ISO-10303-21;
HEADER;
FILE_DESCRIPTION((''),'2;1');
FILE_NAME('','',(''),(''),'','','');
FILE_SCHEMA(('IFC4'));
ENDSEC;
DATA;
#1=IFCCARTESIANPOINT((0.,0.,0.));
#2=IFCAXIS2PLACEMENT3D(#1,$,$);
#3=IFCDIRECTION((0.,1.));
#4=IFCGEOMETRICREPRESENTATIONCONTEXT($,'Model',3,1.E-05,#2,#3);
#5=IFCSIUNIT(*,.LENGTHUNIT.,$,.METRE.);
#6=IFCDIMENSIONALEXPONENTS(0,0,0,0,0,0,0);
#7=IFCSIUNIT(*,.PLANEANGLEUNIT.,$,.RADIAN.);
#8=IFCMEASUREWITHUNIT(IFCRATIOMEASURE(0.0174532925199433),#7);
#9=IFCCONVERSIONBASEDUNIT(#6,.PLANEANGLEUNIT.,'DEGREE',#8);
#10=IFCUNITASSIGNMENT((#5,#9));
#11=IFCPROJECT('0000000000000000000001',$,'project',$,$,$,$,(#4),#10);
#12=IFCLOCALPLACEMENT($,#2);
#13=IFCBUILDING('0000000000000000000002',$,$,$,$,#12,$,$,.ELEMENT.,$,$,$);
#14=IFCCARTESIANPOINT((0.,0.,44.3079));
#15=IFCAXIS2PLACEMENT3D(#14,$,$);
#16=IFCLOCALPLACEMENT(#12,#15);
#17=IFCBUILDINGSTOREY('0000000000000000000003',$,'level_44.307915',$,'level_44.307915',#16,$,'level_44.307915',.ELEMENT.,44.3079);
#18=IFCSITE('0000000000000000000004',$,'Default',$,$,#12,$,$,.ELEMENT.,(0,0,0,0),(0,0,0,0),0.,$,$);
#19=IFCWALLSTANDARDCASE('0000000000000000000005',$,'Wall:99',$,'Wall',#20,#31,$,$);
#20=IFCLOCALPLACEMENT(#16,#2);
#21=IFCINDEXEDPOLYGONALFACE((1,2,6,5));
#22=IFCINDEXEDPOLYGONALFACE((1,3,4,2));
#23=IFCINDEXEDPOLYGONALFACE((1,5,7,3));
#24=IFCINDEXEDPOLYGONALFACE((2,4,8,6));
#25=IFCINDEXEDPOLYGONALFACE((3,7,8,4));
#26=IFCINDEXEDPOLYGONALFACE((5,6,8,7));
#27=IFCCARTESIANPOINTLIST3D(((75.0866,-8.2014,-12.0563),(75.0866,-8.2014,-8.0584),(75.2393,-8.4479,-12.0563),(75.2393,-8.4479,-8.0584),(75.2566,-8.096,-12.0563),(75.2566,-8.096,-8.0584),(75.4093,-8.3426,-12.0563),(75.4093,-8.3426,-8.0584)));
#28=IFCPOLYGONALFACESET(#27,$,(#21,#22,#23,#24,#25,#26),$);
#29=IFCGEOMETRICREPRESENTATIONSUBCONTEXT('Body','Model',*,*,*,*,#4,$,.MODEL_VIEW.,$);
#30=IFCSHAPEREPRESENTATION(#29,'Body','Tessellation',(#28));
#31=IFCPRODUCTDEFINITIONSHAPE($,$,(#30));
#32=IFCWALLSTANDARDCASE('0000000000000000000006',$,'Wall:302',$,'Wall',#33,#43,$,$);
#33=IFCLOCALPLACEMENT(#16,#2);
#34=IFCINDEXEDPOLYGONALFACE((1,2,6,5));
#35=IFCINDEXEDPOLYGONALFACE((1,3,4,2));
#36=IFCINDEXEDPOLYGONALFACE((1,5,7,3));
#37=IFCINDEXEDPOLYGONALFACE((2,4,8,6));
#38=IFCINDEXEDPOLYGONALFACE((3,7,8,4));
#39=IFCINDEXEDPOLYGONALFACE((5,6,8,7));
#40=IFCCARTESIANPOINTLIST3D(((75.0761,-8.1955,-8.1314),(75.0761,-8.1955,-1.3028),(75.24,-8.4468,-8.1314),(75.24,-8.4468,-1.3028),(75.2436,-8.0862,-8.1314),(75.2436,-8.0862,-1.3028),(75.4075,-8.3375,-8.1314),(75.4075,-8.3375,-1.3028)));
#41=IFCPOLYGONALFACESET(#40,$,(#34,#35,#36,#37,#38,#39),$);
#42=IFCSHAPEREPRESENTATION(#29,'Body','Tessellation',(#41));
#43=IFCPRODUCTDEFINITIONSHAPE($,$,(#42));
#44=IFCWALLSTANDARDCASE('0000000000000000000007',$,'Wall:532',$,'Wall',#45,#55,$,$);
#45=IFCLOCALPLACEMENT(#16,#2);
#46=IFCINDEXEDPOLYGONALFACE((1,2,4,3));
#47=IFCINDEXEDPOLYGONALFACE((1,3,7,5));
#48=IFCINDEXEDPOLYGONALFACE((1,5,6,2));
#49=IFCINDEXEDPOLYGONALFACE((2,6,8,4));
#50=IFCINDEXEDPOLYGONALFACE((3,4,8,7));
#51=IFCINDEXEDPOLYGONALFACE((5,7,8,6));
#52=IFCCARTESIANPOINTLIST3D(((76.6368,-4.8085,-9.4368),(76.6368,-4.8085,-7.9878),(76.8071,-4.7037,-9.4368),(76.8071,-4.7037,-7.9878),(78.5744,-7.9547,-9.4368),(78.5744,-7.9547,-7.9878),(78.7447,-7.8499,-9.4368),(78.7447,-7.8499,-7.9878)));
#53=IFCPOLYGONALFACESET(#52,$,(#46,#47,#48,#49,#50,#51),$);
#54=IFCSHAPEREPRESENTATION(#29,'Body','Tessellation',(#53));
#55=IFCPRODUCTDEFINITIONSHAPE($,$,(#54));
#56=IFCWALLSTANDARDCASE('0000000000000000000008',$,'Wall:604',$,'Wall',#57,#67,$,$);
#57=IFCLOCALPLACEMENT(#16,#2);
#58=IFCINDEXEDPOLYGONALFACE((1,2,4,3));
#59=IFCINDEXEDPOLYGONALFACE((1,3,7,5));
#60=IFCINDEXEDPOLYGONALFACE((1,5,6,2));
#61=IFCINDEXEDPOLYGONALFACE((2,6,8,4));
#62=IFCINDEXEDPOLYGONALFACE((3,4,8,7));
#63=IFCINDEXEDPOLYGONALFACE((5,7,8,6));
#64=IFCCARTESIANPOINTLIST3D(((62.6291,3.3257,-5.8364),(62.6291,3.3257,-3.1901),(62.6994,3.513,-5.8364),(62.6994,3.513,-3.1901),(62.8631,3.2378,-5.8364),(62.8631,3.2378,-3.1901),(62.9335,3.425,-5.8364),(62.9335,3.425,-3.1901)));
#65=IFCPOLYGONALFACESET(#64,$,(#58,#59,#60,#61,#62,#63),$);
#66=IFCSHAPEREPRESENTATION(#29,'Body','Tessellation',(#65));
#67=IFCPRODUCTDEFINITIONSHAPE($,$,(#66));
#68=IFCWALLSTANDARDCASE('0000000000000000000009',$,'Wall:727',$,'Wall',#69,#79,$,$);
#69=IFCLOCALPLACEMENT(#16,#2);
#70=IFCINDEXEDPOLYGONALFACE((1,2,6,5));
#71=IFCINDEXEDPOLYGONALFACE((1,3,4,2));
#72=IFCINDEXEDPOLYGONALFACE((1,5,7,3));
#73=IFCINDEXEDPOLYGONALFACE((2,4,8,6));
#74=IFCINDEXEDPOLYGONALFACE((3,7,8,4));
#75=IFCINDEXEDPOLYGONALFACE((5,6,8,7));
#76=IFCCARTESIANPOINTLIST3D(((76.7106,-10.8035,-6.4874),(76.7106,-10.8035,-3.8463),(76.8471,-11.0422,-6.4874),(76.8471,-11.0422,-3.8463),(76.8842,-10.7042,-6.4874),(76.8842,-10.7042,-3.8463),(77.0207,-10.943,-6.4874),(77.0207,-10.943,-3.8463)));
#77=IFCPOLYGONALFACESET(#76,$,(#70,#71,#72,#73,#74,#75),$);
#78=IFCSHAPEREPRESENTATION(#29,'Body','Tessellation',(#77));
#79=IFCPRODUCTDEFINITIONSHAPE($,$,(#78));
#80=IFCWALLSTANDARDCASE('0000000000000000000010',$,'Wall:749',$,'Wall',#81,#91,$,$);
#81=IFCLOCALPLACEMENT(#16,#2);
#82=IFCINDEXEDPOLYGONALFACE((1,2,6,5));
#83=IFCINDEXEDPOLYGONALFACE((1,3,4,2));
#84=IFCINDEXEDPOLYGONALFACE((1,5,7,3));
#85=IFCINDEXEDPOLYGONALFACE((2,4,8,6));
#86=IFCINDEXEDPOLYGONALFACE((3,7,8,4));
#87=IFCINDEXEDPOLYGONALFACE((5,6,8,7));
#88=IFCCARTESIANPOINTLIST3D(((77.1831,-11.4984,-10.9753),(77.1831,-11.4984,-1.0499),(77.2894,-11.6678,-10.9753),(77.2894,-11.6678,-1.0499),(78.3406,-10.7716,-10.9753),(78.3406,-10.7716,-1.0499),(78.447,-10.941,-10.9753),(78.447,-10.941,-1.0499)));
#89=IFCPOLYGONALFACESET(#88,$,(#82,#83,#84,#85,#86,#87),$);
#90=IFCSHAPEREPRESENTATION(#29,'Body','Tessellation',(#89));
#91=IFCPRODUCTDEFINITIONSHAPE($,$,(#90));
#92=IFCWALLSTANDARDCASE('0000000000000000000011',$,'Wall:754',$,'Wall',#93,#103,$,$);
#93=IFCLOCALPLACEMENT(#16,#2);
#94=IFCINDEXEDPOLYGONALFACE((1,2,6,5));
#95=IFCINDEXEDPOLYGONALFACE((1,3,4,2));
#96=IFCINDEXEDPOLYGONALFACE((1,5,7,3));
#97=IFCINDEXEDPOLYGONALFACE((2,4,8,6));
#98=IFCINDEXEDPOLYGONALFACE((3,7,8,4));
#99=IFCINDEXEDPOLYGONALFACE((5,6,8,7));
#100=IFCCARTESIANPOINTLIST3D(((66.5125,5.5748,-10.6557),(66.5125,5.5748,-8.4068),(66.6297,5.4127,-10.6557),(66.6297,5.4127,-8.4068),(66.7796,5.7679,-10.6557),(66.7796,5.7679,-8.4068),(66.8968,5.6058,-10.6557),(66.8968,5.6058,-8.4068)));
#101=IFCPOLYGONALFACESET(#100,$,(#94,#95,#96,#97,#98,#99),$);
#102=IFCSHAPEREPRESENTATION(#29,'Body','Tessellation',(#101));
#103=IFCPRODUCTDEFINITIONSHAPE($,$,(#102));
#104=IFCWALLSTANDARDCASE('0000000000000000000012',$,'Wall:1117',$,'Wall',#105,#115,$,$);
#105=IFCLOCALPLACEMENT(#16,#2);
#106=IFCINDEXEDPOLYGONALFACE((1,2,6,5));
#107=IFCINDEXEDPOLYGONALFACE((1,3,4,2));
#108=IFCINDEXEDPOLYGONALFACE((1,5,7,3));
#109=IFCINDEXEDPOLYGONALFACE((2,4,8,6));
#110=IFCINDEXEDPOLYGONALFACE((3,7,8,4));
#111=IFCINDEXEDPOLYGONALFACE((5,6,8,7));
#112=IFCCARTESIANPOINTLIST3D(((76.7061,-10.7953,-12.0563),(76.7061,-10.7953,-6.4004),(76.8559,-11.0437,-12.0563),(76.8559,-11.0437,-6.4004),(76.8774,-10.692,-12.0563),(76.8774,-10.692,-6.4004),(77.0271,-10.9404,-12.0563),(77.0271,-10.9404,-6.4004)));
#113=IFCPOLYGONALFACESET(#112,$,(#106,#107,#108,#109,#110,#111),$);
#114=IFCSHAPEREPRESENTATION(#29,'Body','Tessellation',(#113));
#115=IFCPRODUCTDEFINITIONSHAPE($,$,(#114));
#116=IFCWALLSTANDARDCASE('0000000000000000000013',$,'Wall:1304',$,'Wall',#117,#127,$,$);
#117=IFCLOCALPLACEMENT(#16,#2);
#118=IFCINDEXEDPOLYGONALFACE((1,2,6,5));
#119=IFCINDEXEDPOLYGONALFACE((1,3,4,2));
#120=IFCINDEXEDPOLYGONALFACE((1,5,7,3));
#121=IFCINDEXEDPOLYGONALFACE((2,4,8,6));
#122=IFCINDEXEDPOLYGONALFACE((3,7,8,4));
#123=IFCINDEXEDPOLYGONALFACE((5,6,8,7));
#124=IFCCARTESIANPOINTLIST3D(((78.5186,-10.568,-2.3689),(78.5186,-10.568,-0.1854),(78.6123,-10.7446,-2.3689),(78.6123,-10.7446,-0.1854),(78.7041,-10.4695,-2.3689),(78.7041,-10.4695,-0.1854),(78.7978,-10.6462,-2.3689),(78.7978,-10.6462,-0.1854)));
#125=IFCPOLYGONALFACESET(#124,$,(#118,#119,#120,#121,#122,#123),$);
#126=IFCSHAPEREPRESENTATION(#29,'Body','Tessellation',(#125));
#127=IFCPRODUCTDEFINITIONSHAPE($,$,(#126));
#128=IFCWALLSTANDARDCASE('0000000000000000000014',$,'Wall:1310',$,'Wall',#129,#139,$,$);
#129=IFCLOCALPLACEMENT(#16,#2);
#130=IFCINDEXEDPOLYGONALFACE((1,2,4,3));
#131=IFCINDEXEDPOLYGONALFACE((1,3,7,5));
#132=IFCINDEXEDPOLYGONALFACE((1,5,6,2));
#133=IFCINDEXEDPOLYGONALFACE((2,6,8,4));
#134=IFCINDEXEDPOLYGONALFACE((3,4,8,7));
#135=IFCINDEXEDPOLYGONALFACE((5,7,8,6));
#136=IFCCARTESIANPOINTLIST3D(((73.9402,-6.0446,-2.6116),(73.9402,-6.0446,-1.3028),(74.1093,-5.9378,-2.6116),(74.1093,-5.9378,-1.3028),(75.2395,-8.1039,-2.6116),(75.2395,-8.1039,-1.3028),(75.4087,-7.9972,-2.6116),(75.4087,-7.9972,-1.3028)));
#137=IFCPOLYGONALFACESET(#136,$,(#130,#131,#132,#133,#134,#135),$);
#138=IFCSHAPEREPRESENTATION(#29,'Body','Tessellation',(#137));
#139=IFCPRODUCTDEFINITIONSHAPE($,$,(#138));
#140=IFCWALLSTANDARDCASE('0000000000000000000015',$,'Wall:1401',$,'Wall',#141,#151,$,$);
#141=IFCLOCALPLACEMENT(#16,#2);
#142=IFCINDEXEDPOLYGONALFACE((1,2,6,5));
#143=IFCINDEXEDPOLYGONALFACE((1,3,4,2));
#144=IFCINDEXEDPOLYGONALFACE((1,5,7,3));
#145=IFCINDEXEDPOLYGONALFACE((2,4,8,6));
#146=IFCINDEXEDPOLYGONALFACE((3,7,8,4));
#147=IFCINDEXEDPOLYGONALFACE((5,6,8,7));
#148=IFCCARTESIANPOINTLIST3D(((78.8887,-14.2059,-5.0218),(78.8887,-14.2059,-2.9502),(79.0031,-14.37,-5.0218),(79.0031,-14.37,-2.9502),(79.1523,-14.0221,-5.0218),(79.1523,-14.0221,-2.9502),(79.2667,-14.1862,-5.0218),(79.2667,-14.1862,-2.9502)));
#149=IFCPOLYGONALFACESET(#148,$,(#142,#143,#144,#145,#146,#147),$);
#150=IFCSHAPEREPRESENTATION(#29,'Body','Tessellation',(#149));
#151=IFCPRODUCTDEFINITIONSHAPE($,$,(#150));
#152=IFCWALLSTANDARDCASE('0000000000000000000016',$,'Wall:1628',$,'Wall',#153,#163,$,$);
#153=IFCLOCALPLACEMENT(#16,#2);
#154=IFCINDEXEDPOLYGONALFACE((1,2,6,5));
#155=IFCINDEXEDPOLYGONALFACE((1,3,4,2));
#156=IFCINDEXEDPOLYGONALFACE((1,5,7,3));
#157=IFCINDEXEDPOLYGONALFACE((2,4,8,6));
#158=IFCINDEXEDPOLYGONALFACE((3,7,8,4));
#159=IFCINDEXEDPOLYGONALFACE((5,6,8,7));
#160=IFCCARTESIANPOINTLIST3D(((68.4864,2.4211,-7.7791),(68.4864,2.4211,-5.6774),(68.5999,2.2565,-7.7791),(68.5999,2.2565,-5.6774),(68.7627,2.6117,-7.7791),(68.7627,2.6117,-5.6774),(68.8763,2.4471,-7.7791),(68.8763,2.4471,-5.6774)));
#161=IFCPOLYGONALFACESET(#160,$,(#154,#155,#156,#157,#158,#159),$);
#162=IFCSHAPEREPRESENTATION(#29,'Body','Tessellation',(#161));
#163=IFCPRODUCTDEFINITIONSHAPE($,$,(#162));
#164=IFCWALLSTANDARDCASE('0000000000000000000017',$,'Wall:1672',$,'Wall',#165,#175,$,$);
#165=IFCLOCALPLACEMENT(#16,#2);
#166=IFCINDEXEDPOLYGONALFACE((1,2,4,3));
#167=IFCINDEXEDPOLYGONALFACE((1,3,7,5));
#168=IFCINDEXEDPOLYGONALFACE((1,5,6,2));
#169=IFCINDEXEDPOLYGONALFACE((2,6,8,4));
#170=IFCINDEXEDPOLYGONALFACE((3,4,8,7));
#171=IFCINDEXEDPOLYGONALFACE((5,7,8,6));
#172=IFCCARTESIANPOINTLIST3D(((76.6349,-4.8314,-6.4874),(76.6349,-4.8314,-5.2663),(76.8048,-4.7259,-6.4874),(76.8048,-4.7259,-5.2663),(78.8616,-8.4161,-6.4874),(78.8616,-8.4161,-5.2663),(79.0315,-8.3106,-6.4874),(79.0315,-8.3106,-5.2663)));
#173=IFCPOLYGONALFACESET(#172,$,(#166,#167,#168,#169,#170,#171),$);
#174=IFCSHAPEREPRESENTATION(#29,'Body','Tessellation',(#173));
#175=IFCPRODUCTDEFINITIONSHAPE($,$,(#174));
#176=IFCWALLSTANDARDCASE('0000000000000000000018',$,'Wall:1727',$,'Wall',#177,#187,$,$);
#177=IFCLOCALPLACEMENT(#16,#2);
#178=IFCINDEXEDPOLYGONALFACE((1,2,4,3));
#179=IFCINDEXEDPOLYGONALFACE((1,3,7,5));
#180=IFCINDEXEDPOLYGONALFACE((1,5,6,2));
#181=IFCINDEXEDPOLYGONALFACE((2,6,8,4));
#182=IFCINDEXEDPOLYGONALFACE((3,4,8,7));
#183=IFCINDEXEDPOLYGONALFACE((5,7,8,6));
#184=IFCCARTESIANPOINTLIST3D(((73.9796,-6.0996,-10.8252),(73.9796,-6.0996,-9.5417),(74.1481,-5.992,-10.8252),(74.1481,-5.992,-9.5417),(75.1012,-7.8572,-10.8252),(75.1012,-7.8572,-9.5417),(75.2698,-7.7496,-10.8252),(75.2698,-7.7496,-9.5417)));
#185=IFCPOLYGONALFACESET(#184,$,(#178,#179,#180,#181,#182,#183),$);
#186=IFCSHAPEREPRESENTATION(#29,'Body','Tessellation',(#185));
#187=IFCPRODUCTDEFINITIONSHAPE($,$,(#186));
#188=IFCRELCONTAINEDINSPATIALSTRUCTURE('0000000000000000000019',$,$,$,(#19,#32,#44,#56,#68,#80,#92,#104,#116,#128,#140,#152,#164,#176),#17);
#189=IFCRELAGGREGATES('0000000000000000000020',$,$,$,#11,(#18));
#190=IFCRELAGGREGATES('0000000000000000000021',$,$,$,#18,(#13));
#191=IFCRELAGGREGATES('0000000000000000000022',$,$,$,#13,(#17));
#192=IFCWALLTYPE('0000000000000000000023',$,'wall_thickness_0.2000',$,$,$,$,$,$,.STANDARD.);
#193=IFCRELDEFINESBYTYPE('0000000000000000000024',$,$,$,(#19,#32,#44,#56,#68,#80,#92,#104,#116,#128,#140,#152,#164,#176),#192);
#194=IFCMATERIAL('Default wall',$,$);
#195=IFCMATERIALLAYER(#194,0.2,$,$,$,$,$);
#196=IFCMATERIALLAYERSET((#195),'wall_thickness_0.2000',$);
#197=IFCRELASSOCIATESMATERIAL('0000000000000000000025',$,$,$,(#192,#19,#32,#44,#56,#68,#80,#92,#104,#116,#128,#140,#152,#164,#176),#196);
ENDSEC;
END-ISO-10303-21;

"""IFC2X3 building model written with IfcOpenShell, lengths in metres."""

from ifc_helpers import new_model, entity, si_unit, converted_unit, direction, frame, origin, place, context, subcontext, project, spatial, polyline, outline, extrude, material, layer, layer_set, layer_usage, type_object, element, save


model = new_model("IFC2X3")

# Units and contexts
model_context = context("Model", 3, precision=1e-05, world=origin(), true_north=direction((0.0, 1.0)))
body_context = subcontext(model_context, "Body", "Model", "MODEL_VIEW")
ifc_project = project(units=[si_unit("LENGTHUNIT", "METRE"), converted_unit("PLANEANGLEUNIT", "DEGREE", entity("IfcRatioMeasure", 0.0174532925199433), si_unit("PLANEANGLEUNIT", "RADIAN"), dimensions=[0, 0, 0, 0, 0, 0, 0])], contexts=[model_context])

# Site, building, storey
placement_1 = place(None, origin())
site = spatial("IfcSite", under=ifc_project, at=placement_1, Name="Default", CompositionType="ELEMENT", RefLatitude=(0, 0, 0, 0), RefLongitude=(0, 0, 0, 0), RefElevation=0.0)
building = spatial("IfcBuilding", under=site, at=placement_1, CompositionType="ELEMENT")
storey_placement = place(placement_1, frame((0.0, 0.0, 44.3079)))
storey = spatial("IfcBuildingStorey", under=building, at=storey_placement, Name="level_44.307915", ObjectType="level_44.307915", LongName="level_44.307915", CompositionType="ELEMENT", Elevation=44.3079)

# Walls
ifc_material_1 = material(Name="Default wall")
ifc_layer = layer(ifc_material_1, 0.2)
ifc_layer_set = layer_set([ifc_layer], Name="wall_thickness_0.2000")
ifc_layer_usage = layer_usage(ifc_layer_set, "AXIS2", "POSITIVE", -0.1)
wall_type = type_object("IfcWallType", Name="wall_thickness_0.2000", PredefinedType="STANDARD", material=ifc_layer_set)
placement_2 = place(placement_1, frame((0.0, 0.0, 32.2516)))
wall_1_placement = place(placement_2, frame((75.1716, -8.1487, 0.0), z_axis=(0.0, 0.0, 1.0), x_axis=(0.526642, -0.850087, 0.0)))
element("IfcWallStandardCase", 1, at=wall_1_placement, inside=storey, type_object=wall_type, material=ifc_layer_usage, Name="Wall:99", ObjectType="Wall", context=body_context, shape_type="SweptSolid", body=[
    extrude(outline(polyline([(0.29, -0.1), (0.29, 0.1), (0.0, 0.1), (0.0, -0.1), (0.29, -0.1)])), origin(), (0.0, 0.0, 1.0), 3.9979),
])
placement_3 = place(placement_1, frame((0.0, 0.0, 36.1765)))
wall_2_placement = place(placement_3, frame((75.1598, -8.1409, 0.0), z_axis=(0.0, 0.0, 1.0), x_axis=(0.54634, -0.837563, 0.0)))
element("IfcWallStandardCase", 2, at=wall_2_placement, inside=storey, type_object=wall_type, material=ifc_layer_usage, Name="Wall:302", ObjectType="Wall", context=body_context, shape_type="SweptSolid", body=[
    extrude(outline(polyline([(0.3, -0.1), (0.3, 0.1), (0.0, 0.1), (0.0, -0.1), (0.3, -0.1)])), origin(), (0.0, 0.0, 1.0), 6.8286),
])
placement_4 = place(placement_1, frame((0.0, 0.0, 34.8711)))
wall_3_placement = place(placement_4, frame((76.722, -4.7561, 0.0), z_axis=(0.0, 0.0, 1.0), x_axis=(0.524388, -0.851479, 0.0)))
element("IfcWallStandardCase", 3, at=wall_3_placement, inside=storey, type_object=wall_type, material=ifc_layer_usage, Name="Wall:532", ObjectType="Wall", context=body_context, shape_type="SweptSolid", body=[
    extrude(outline(polyline([(3.695, -0.1), (3.695, 0.1), (0.0, 0.1), (0.0, -0.1), (3.695, -0.1)])), origin(), (0.0, 0.0, 1.0), 1.4491),
])
placement_5 = place(placement_1, frame((0.0, 0.0, 38.4715)))
wall_4_placement = place(placement_5, frame((62.8983, 3.3314, 0.0), z_axis=(0.0, 0.0, 1.0), x_axis=(-0.93611, 0.351706, 0.0)))
element("IfcWallStandardCase", 4, at=wall_4_placement, inside=storey, type_object=wall_type, material=ifc_layer_usage, Name="Wall:604", ObjectType="Wall", context=body_context, shape_type="SweptSolid", body=[
    extrude(outline(polyline([(0.25, -0.1), (0.25, 0.1), (0.0, 0.1), (0.0, -0.1), (0.25, -0.1)])), origin(), (0.0, 0.0, 1.0), 2.6463),
])

# Walls
placement_6 = place(placement_1, frame((0.0, 0.0, 37.8205)))
wall_5_placement = place(placement_6, frame((76.9339, -10.9926, 0.0), z_axis=(0.0, 0.0, 1.0), x_axis=(-0.496353, 0.868121, 0.0)))
element("IfcWallStandardCase", 5, at=wall_5_placement, inside=storey, type_object=wall_type, material=ifc_layer_usage, Name="Wall:727", ObjectType="Wall", context=body_context, shape_type="SweptSolid", body=[
    extrude(outline(polyline([(0.275, -0.1), (0.275, 0.1), (0.0, 0.1), (0.0, -0.1), (0.275, -0.1)])), origin(), (0.0, 0.0, 1.0), 2.641),
])
placement_7 = place(placement_1, frame((0.0, 0.0, 33.3326)))
wall_6_placement = place(placement_7, frame((77.2363, -11.5831, 0.0), z_axis=(0.0, 0.0, 1.0), x_axis=(0.846909, 0.531738, 0.0)))
element("IfcWallStandardCase", 6, at=wall_6_placement, inside=storey, type_object=wall_type, material=ifc_layer_usage, Name="Wall:749", ObjectType="Wall", context=body_context, shape_type="SweptSolid", body=[
    extrude(outline(polyline([(1.3668, -0.1), (1.3668, 0.1), (0.0, 0.1), (0.0, -0.1), (1.3668, -0.1)])), origin(), (0.0, 0.0, 1.0), 9.9254),
])
placement_8 = place(placement_1, frame((0.0, 0.0, 33.6522)))
wall_7_placement = place(placement_8, frame((66.8382, 5.6869, 0.0), z_axis=(0.0, 0.0, 1.0), x_axis=(-0.810408, -0.585866, 0.0)))
element("IfcWallStandardCase", 7, at=wall_7_placement, inside=storey, type_object=wall_type, material=ifc_layer_usage, Name="Wall:754", ObjectType="Wall", context=body_context, shape_type="SweptSolid", body=[
    extrude(outline(polyline([(0.3296, -0.1), (0.3296, 0.1), (0.0, 0.1), (0.0, -0.1), (0.3296, -0.1)])), origin(), (0.0, 0.0, 1.0), 2.2488),
])
placement_9 = place(placement_1, frame((0.0, 0.0, 32.2516)))
wall_8_placement = place(placement_9, frame((76.9415, -10.992, 0.0), z_axis=(0.0, 0.0, 1.0), x_axis=(-0.516432, 0.856328, 0.0)))
element("IfcWallStandardCase", 8, at=wall_8_placement, inside=storey, type_object=wall_type, material=ifc_layer_usage, Name="Wall:1117", ObjectType="Wall", context=body_context, shape_type="SweptSolid", body=[
    extrude(outline(polyline([(0.29, -0.1), (0.29, 0.1), (0.0, 0.1), (0.0, -0.1), (0.29, -0.1)])), origin(), (0.0, 0.0, 1.0), 5.6559),
])
placement_10 = place(placement_1, frame((0.0, 0.0, 41.939)))
wall_9_placement = place(placement_10, frame((78.751, -10.5579, 0.0), z_axis=(0.0, 0.0, 1.0), x_axis=(-0.883322, -0.468767, 0.0)))
element("IfcWallStandardCase", 9, at=wall_9_placement, inside=storey, type_object=wall_type, material=ifc_layer_usage, Name="Wall:1304", ObjectType="Wall", context=body_context, shape_type="SweptSolid", body=[
    extrude(outline(polyline([(0.21, -0.1), (0.21, 0.1), (0.0, 0.1), (0.0, -0.1), (0.21, -0.1)])), origin(), (0.0, 0.0, 1.0), 2.1835),
])
placement_11 = place(placement_1, frame((0.0, 0.0, 41.6963)))
wall_10_placement = place(placement_11, frame((74.0248, -5.9912, 0.0), z_axis=(0.0, 0.0, 1.0), x_axis=(0.533597, -0.845739, 0.0)))
element("IfcWallStandardCase", 10, at=wall_10_placement, inside=storey, type_object=wall_type, material=ifc_layer_usage, Name="Wall:1310", ObjectType="Wall", context=body_context, shape_type="SweptSolid", body=[
    extrude(outline(polyline([(2.435, -0.1), (2.435, 0.1), (0.0, 0.1), (0.0, -0.1), (2.435, -0.1)])), origin(), (0.0, 0.0, 1.0), 1.3088),
])
placement_12 = place(placement_1, frame((0.0, 0.0, 39.2861)))
wall_11_placement = place(placement_12, frame((78.9459, -14.2879, 0.0), z_axis=(0.0, 0.0, 1.0), x_axis=(0.820275, 0.57197, 0.0)))
element("IfcWallStandardCase", 11, at=wall_11_placement, inside=storey, type_object=wall_type, material=ifc_layer_usage, Name="Wall:1401", ObjectType="Wall", context=body_context, shape_type="SweptSolid", body=[
    extrude(outline(polyline([(0.3213, -0.1), (0.3213, 0.1), (0.0, 0.1), (0.0, -0.1), (0.3213, -0.1)])), origin(), (0.0, 0.0, 1.0), 2.0716),
])
placement_13 = place(placement_1, frame((0.0, 0.0, 36.5288)))
wall_12_placement = place(placement_13, frame((68.8195, 2.5294, 0.0), z_axis=(0.0, 0.0, 1.0), x_axis=(-0.823176, -0.567786, 0.0)))
element("IfcWallStandardCase", 12, at=wall_12_placement, inside=storey, type_object=wall_type, material=ifc_layer_usage, Name="Wall:1628", ObjectType="Wall", context=body_context, shape_type="SweptSolid", body=[
    extrude(outline(polyline([(0.3357, -0.1), (0.3357, 0.1), (0.0, 0.1), (0.0, -0.1), (0.3357, -0.1)])), origin(), (0.0, 0.0, 1.0), 2.1017),
])
placement_14 = place(placement_1, frame((0.0, 0.0, 37.8205)))
wall_13_placement = place(placement_14, frame((76.7198, -4.7787, 0.0), z_axis=(0.0, 0.0, 1.0), x_axis=(0.527663, -0.849454, 0.0)))
element("IfcWallStandardCase", 13, at=wall_13_placement, inside=storey, type_object=wall_type, material=ifc_layer_usage, Name="Wall:1672", ObjectType="Wall", context=body_context, shape_type="SweptSolid", body=[
    extrude(outline(polyline([(4.22, -0.1), (4.22, 0.1), (0.0, 0.1), (0.0, -0.1), (4.22, -0.1)])), origin(), (0.0, 0.0, 1.0), 1.221),
])
placement_15 = place(placement_1, frame((0.0, 0.0, 33.4827)))
wall_14_placement = place(placement_15, frame((74.0638, -6.0458, 0.0), z_axis=(0.0, 0.0, 1.0), x_axis=(0.537939, -0.842983, 0.0)))
element("IfcWallStandardCase", 14, at=wall_14_placement, inside=storey, type_object=wall_type, material=ifc_layer_usage, Name="Wall:1727", ObjectType="Wall", context=body_context, shape_type="SweptSolid", body=[
    extrude(outline(polyline([(2.085, -0.1), (2.085, 0.1), (0.0, 0.1), (0.0, -0.1), (2.085, -0.1)])), origin(), (0.0, 0.0, 1.0), 1.2835),
])

save(model, "model.ifc")
